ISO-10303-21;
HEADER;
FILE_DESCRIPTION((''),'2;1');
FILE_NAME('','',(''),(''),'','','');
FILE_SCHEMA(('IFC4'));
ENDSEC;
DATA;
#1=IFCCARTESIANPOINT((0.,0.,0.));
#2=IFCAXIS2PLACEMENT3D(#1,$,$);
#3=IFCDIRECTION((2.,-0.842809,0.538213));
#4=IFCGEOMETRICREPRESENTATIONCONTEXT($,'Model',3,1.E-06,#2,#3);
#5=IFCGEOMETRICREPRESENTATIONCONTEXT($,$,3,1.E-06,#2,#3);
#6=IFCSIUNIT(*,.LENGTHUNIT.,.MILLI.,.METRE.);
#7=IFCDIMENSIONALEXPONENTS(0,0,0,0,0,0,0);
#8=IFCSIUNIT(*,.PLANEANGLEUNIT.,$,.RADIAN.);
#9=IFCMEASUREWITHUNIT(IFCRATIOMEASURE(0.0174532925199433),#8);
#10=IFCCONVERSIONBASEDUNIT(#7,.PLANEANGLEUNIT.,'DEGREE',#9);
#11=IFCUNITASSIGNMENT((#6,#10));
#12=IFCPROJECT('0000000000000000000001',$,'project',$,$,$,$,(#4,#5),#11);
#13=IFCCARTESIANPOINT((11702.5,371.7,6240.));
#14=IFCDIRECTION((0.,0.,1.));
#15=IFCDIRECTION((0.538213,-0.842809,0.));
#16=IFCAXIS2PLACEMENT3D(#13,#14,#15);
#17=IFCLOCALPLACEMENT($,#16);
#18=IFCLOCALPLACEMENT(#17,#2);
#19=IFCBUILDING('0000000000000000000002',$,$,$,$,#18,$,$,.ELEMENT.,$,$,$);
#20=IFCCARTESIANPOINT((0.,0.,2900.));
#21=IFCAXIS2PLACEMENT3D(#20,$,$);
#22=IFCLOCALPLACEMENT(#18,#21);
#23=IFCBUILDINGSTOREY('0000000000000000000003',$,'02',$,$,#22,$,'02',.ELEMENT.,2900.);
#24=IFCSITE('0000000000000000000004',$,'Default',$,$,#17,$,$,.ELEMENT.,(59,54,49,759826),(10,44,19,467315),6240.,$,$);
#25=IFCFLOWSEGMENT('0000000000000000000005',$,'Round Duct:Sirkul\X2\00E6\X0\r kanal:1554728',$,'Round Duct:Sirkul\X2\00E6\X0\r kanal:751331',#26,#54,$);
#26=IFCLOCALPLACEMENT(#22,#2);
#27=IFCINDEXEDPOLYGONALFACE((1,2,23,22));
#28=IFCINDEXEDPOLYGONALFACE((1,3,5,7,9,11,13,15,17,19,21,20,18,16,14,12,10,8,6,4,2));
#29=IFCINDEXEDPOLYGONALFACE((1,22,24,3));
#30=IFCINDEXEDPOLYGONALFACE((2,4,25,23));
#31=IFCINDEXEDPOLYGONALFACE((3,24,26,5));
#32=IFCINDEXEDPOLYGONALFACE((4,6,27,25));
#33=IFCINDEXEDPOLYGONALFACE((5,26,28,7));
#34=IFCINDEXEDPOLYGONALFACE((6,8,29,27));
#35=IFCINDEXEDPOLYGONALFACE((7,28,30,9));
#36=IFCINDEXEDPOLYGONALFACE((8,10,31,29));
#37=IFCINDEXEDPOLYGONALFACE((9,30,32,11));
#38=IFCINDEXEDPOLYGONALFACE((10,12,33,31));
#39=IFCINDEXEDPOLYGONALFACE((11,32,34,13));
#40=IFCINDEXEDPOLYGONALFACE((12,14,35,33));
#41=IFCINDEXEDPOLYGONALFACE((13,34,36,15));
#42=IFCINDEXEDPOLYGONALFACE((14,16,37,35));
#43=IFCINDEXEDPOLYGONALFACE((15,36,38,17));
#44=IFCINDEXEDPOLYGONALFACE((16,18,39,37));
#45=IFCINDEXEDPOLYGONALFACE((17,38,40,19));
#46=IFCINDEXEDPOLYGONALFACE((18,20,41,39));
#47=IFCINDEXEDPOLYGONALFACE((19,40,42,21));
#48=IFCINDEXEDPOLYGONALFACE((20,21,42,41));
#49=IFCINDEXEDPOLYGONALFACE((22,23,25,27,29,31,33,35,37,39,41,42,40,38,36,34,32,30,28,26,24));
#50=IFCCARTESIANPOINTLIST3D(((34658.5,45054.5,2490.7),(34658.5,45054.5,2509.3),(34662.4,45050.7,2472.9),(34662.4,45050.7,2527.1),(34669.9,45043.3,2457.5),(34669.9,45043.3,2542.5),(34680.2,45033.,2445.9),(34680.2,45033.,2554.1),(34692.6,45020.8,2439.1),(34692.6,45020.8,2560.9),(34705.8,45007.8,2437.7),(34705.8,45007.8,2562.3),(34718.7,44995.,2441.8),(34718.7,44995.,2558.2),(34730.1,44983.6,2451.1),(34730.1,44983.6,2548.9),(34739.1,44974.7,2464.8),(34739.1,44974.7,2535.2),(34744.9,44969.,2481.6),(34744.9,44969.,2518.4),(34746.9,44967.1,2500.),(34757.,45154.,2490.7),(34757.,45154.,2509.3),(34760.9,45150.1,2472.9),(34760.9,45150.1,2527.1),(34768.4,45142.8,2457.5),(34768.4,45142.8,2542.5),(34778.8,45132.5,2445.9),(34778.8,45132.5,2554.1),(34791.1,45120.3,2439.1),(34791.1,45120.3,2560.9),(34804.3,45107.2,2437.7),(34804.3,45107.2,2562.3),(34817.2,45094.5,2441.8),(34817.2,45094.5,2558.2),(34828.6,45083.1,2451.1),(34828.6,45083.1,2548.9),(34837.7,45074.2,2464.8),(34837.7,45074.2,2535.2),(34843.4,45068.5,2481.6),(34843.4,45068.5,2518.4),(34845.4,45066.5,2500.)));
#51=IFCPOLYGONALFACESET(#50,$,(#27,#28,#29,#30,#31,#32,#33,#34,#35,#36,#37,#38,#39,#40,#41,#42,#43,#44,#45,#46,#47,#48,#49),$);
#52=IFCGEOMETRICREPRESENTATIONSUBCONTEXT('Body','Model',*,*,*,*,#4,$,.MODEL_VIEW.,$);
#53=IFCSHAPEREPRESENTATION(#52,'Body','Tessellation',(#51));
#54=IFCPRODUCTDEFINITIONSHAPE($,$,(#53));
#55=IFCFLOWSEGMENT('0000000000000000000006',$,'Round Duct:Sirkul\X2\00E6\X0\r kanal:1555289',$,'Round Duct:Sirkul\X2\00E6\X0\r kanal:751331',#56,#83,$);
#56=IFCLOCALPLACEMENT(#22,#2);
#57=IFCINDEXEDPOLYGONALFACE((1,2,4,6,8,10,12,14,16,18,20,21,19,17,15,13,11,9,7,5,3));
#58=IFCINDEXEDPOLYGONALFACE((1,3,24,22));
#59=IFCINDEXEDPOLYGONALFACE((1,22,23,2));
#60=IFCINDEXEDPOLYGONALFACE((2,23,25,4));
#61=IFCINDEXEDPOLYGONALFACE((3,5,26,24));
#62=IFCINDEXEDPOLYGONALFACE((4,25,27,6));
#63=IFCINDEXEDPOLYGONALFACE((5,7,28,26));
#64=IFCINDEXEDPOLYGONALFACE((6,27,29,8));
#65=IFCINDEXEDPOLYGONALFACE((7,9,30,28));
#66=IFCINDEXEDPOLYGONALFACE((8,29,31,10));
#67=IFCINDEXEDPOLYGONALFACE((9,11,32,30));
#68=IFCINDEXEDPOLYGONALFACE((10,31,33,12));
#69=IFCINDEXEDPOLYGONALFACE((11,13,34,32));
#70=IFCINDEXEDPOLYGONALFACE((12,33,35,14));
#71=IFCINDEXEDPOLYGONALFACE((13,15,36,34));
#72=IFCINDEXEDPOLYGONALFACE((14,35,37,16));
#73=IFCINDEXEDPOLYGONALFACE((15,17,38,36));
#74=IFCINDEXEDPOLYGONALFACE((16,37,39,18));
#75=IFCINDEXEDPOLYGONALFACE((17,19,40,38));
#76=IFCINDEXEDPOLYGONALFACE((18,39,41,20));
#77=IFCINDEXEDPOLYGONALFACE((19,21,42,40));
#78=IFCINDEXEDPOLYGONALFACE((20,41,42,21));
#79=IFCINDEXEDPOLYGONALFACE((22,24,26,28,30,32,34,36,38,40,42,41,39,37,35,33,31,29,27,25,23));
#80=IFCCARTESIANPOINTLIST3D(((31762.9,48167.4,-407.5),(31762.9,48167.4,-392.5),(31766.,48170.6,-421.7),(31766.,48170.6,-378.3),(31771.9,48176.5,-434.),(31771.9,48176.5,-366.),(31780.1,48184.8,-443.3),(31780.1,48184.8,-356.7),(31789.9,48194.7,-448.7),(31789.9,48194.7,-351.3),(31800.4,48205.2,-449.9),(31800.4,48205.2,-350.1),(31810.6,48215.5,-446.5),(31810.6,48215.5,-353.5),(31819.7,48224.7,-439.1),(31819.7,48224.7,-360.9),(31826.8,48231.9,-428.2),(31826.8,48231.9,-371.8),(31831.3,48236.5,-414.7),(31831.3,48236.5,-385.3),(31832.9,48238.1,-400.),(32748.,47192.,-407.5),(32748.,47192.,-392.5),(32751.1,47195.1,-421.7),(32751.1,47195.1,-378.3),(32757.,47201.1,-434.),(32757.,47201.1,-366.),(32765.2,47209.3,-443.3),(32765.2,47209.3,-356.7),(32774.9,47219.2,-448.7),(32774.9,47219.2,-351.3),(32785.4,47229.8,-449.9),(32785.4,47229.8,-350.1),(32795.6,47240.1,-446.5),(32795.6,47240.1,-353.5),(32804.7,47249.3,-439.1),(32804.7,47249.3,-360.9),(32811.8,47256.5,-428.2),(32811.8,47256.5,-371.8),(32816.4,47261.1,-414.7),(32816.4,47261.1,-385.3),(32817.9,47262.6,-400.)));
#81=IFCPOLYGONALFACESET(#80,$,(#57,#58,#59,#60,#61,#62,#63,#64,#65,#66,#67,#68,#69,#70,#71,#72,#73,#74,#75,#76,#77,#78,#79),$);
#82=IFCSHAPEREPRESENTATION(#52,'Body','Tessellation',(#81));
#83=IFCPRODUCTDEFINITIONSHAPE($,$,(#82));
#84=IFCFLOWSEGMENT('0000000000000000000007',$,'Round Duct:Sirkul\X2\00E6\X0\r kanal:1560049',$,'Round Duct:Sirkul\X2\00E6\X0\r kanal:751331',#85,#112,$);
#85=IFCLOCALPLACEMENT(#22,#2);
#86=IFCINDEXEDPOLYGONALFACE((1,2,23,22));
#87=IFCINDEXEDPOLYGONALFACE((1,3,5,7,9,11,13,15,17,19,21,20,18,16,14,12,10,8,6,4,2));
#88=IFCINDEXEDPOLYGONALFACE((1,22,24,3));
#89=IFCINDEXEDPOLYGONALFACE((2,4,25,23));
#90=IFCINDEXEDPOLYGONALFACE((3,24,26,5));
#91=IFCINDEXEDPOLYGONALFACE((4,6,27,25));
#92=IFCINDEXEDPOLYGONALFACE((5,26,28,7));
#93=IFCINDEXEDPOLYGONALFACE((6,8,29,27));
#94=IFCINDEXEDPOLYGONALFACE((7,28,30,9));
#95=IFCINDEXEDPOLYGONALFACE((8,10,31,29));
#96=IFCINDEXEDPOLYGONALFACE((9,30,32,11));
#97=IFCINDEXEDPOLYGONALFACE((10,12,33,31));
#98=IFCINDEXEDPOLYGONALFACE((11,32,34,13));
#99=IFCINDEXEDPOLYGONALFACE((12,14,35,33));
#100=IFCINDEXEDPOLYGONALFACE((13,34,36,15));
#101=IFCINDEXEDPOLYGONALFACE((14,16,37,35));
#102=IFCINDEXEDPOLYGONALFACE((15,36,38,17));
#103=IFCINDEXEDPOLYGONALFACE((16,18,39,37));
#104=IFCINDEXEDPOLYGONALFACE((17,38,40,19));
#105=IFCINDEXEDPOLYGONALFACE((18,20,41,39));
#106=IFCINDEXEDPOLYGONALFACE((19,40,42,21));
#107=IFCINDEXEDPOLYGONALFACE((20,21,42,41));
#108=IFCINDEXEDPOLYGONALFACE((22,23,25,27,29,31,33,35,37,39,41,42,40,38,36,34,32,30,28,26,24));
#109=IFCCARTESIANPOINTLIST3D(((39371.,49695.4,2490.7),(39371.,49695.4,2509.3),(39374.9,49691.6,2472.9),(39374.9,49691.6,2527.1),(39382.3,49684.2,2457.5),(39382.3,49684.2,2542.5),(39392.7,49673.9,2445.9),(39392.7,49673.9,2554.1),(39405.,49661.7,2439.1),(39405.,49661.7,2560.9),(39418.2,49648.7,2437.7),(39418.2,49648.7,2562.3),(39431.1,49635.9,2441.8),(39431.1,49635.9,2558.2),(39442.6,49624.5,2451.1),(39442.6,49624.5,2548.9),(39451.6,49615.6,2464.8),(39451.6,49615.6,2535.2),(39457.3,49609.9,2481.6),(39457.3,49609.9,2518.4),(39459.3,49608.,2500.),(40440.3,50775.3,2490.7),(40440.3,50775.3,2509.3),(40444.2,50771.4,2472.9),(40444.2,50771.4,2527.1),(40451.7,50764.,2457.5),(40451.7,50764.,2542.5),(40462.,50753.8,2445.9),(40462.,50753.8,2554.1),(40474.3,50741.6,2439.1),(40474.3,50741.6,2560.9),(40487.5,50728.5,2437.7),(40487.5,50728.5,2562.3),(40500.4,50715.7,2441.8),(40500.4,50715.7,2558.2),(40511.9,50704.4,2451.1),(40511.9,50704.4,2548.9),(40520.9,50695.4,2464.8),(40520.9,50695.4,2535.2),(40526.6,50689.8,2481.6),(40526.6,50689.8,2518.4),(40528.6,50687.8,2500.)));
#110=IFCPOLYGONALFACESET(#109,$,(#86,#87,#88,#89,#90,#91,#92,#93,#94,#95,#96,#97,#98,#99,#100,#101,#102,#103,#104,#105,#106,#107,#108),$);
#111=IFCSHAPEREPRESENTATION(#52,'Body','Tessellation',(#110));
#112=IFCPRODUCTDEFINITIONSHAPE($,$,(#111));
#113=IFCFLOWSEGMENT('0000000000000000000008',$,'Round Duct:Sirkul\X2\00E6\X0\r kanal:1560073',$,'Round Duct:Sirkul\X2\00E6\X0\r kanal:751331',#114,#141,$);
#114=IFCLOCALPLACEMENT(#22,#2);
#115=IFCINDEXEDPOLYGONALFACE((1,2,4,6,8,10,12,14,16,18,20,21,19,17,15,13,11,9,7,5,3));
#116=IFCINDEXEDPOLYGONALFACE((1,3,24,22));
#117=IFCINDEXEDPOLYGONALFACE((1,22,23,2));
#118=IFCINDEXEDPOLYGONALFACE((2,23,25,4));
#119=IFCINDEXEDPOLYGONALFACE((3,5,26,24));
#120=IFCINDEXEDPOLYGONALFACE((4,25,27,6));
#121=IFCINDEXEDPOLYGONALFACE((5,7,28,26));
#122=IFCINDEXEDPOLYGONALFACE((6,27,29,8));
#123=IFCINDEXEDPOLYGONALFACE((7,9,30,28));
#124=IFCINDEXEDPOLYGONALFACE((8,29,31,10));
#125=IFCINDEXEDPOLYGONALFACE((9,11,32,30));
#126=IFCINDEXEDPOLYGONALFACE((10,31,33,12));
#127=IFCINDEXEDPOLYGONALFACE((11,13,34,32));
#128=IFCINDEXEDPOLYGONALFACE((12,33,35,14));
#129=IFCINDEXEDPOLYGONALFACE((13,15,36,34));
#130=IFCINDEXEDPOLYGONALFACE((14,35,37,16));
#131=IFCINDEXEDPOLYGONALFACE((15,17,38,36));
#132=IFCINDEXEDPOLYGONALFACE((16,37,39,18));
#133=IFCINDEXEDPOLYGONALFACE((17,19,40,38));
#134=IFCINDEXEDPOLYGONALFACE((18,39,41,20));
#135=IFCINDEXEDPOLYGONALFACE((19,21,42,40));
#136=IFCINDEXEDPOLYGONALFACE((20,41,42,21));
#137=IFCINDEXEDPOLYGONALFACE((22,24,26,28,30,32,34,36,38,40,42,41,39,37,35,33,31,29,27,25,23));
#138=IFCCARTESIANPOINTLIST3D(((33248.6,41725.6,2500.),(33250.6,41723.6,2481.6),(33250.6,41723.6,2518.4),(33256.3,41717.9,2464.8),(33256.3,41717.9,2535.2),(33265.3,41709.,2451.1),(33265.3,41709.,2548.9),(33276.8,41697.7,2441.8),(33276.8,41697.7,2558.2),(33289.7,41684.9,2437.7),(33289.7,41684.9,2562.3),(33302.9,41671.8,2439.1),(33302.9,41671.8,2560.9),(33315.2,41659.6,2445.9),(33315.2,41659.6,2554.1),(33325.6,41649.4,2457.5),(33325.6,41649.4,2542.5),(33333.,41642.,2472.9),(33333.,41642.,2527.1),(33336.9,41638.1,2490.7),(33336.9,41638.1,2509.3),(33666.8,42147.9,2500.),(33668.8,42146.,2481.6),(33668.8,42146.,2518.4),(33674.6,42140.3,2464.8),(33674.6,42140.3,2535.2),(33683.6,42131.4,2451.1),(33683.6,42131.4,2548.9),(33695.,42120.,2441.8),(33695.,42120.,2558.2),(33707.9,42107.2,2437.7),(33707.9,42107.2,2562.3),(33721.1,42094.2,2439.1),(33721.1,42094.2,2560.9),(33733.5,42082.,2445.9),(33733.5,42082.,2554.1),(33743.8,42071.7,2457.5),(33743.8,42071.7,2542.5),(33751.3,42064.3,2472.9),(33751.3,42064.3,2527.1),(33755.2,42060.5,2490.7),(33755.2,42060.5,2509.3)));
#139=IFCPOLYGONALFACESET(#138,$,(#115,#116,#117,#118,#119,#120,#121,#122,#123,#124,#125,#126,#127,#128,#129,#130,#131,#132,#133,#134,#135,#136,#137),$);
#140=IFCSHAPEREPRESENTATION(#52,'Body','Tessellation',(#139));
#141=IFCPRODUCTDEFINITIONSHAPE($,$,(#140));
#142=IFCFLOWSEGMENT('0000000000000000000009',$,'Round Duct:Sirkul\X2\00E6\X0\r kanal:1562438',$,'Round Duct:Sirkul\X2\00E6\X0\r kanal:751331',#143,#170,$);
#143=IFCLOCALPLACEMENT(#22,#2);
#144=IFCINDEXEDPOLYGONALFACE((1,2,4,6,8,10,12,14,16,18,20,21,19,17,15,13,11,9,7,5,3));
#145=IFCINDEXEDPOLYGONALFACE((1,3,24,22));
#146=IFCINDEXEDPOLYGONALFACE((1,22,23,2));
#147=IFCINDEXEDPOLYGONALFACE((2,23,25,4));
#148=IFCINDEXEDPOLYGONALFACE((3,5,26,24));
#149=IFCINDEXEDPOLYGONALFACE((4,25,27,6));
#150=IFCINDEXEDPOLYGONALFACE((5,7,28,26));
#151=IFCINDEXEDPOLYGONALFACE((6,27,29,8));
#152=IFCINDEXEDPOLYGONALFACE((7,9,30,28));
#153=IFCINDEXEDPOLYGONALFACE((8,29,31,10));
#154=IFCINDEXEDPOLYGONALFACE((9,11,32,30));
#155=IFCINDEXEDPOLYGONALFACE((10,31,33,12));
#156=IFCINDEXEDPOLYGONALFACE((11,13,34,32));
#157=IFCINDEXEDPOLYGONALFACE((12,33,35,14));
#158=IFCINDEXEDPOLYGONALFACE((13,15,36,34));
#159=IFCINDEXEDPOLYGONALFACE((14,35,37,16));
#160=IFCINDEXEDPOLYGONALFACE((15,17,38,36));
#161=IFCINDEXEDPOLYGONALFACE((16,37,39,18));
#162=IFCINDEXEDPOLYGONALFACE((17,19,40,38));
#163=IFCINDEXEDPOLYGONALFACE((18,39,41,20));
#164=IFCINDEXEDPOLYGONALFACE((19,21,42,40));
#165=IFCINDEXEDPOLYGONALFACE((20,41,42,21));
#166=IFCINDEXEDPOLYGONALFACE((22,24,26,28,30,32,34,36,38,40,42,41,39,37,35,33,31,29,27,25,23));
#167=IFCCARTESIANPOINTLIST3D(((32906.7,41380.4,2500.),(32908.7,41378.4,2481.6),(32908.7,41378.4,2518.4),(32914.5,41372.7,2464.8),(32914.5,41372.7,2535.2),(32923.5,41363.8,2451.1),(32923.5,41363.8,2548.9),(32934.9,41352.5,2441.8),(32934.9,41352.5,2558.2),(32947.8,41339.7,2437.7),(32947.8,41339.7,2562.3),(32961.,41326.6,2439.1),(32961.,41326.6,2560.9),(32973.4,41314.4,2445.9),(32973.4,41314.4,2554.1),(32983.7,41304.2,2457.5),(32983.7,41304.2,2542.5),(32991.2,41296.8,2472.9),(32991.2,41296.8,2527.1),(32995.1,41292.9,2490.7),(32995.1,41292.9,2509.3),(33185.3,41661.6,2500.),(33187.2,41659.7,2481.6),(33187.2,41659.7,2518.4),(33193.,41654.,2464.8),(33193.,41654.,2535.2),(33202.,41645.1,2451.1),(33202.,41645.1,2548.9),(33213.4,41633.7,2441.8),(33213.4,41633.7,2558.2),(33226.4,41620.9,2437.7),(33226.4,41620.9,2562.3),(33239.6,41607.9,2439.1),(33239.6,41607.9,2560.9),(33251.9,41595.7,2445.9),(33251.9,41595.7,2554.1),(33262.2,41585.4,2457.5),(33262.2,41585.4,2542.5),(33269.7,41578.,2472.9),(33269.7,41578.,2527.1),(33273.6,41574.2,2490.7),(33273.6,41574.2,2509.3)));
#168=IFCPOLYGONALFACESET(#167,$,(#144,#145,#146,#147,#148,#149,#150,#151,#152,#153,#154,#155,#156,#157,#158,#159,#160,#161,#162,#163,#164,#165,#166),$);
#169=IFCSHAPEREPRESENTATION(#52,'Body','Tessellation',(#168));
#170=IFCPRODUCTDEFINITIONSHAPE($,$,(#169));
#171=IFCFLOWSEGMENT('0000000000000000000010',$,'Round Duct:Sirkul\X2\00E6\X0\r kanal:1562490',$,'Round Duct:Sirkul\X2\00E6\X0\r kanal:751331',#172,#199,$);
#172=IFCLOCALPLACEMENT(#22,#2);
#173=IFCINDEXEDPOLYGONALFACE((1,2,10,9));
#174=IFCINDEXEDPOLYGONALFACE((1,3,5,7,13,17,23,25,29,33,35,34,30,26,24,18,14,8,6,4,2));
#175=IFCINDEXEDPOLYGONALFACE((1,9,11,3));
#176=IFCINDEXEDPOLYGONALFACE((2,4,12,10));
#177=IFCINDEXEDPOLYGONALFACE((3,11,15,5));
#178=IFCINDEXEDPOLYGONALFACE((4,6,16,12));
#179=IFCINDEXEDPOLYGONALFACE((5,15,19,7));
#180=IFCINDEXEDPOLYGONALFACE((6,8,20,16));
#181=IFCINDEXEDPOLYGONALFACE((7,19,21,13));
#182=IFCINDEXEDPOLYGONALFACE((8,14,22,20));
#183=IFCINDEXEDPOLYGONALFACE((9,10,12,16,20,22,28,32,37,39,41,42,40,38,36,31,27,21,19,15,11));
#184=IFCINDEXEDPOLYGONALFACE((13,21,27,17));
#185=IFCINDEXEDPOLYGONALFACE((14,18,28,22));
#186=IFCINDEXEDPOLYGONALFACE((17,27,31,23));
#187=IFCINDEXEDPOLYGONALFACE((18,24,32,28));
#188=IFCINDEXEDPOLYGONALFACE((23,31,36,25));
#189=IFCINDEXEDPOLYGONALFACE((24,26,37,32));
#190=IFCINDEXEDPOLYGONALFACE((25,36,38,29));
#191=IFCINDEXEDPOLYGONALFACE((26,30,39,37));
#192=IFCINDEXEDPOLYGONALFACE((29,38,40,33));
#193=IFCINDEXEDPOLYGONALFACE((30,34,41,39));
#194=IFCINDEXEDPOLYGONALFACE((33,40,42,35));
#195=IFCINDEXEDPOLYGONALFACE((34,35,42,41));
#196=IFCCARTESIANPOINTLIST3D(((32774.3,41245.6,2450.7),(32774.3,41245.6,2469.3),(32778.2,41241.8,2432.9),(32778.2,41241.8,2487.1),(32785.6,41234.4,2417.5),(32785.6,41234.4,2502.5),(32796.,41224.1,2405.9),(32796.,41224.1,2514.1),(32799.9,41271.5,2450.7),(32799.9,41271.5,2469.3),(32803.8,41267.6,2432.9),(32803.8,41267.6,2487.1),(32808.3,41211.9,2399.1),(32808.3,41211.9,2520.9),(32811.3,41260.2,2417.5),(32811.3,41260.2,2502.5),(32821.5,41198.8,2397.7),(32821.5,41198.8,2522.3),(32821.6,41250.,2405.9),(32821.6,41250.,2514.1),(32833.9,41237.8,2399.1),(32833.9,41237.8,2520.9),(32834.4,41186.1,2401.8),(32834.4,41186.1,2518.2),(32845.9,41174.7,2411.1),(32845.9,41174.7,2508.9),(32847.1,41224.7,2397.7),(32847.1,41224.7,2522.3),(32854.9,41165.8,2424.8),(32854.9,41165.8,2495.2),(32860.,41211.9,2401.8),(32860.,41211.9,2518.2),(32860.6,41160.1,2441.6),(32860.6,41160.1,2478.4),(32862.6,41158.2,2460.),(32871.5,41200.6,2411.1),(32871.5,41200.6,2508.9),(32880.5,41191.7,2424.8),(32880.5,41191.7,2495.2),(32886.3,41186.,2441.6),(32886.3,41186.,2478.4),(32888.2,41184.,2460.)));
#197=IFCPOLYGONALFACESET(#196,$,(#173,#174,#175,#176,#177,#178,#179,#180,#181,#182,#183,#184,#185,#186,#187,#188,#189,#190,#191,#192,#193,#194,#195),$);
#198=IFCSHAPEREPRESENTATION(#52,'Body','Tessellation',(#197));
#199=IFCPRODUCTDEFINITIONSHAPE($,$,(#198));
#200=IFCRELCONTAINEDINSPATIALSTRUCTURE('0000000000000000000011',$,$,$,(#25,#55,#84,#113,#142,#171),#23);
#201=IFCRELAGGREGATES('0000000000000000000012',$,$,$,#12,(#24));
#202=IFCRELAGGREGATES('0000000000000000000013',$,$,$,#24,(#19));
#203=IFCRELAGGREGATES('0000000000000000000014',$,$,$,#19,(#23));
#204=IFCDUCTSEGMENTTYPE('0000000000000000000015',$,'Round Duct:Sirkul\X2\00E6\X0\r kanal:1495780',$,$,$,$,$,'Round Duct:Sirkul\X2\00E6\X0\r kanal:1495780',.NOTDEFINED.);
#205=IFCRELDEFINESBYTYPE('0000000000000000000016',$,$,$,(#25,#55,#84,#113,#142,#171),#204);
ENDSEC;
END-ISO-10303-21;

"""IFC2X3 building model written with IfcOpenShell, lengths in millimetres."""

from ifc_helpers import new_model, entity, si_unit, converted_unit, direction, frame, origin, origin_2d_with_axis, place, context, subcontext, project, spatial, circle, extrude, type_object, element, save


model = new_model("IFC2X3")

# Units and contexts
model_context = context("Model", 3, precision=1e-06, world=origin(), true_north=direction((2.0, -0.842809, 0.538213)))
context_of_model = context(None, 3, precision=1e-06, world=origin(), true_north=direction((2.0, -0.842809, 0.538213)))
body_context = subcontext(model_context, "Body", "Model", "MODEL_VIEW")
ifc_project = project(units=[si_unit("LENGTHUNIT", "METRE", prefix="MILLI"), converted_unit("PLANEANGLEUNIT", "DEGREE", entity("IfcRatioMeasure", 0.0174532925199433), si_unit("PLANEANGLEUNIT", "RADIAN"), dimensions=[0, 0, 0, 0, 0, 0, 0])], contexts=[model_context, context_of_model])

# Site, building, storey
site_placement = place(None, frame((11702.5, 371.7, 6240.0), z_axis=(0.0, 0.0, 1.0), x_axis=(0.538213, -0.842809, 0.0)))
site = spatial("IfcSite", under=ifc_project, at=site_placement, Name="Default", CompositionType="ELEMENT", RefLatitude=(59, 54, 49, 759826), RefLongitude=(10, 44, 19, 467315), RefElevation=6240.0)
building_placement = place(site_placement, origin())
building = spatial("IfcBuilding", under=site, at=building_placement, CompositionType="ELEMENT")
storey_placement = place(building_placement, frame((0.0, 0.0, 2900.0)))
storey = spatial("IfcBuildingStorey", under=building, at=storey_placement, Name="02", LongName="02", CompositionType="ELEMENT", Elevation=2900.0)

# Flow segments
duct_segment_type = type_object("IfcDuctSegmentType", Name="Round Duct:Sirkulær kanal:1495780", ElementType="Round Duct:Sirkulær kanal:1495780", PredefinedType="NOTDEFINED")
flow_segment_1_placement = place(storey_placement, origin())
element("IfcFlowSegment", 1, at=flow_segment_1_placement, inside=storey, type_object=duct_segment_type, Name="Round Duct:Sirkulær kanal:1554728", ObjectType="Round Duct:Sirkulær kanal:751331", context=body_context, shape_type="SweptSolid", body=[
    extrude(circle(Radius=62.5, at=origin_2d_with_axis()), frame((34702.4, 45011.0, 2500.0), z_axis=(0.703643, 0.710554, 0.0), x_axis=(0.710554, -0.703643, 0.0)), (0.0, 0.0, 1.0), 140.0),
])
flow_segment_2_placement = place(storey_placement, origin())
element("IfcFlowSegment", 2, at=flow_segment_2_placement, inside=storey, type_object=duct_segment_type, Name="Round Duct:Sirkulær kanal:1555289", ObjectType="Round Duct:Sirkulær kanal:751331", context=body_context, shape_type="SweptSolid", body=[
    extrude(circle(Radius=50.0, at=origin_2d_with_axis()), frame((32782.8, 47227.1, -400.0), z_axis=(-0.710554, 0.703643, 0.0), x_axis=(0.703643, 0.710554, 0.0)), (0.0, 0.0, 1.0), 1386.3),
])
flow_segment_3_placement = place(storey_placement, origin())
element("IfcFlowSegment", 3, at=flow_segment_3_placement, inside=storey, type_object=duct_segment_type, Name="Round Duct:Sirkulær kanal:1560049", ObjectType="Round Duct:Sirkulær kanal:751331", context=body_context, shape_type="SweptSolid", body=[
    extrude(circle(Radius=62.5, at=origin_2d_with_axis()), frame((39414.9, 49651.9, 2500.0), z_axis=(0.703643, 0.710554, 0.0), x_axis=(0.710554, -0.703643, 0.0)), (0.0, 0.0, 1.0), 1519.7),
])
flow_segment_4_placement = place(storey_placement, origin())
element("IfcFlowSegment", 4, at=flow_segment_4_placement, inside=storey, type_object=duct_segment_type, Name="Round Duct:Sirkulær kanal:1560073", ObjectType="Round Duct:Sirkulær kanal:751331", context=body_context, shape_type="SweptSolid", body=[
    extrude(circle(Radius=62.5, at=origin_2d_with_axis()), frame((33293.0, 41681.6, 2500.0), z_axis=(0.703643, 0.710554, 0.0), x_axis=(-0.710554, 0.703643, 0.0)), (0.0, 0.0, 1.0), 594.4),
])
flow_segment_5_placement = place(storey_placement, origin())
element("IfcFlowSegment", 5, at=flow_segment_5_placement, inside=storey, type_object=duct_segment_type, Name="Round Duct:Sirkulær kanal:1562438", ObjectType="Round Duct:Sirkulær kanal:751331", context=body_context, shape_type="SweptSolid", body=[
    extrude(circle(Radius=62.5, at=origin_2d_with_axis()), frame((32951.2, 41336.4, 2500.0), z_axis=(0.703643, 0.710554, 0.0), x_axis=(-0.710554, 0.703643, 0.0)), (0.0, 0.0, 1.0), 395.8),
])
flow_segment_6_placement = place(storey_placement, origin())
element("IfcFlowSegment", 6, at=flow_segment_6_placement, inside=storey, type_object=duct_segment_type, Name="Round Duct:Sirkulær kanal:1562490", ObjectType="Round Duct:Sirkulær kanal:751331", context=body_context, shape_type="SweptSolid", body=[
    extrude(circle(Radius=62.5, at=origin_2d_with_axis()), frame((32818.2, 41202.1, 2460.0), z_axis=(0.703643, 0.710554, 0.0), x_axis=(0.710554, -0.703643, 0.0)), (0.0, 0.0, 1.0), 36.4),
])

save(model, "model.ifc")
